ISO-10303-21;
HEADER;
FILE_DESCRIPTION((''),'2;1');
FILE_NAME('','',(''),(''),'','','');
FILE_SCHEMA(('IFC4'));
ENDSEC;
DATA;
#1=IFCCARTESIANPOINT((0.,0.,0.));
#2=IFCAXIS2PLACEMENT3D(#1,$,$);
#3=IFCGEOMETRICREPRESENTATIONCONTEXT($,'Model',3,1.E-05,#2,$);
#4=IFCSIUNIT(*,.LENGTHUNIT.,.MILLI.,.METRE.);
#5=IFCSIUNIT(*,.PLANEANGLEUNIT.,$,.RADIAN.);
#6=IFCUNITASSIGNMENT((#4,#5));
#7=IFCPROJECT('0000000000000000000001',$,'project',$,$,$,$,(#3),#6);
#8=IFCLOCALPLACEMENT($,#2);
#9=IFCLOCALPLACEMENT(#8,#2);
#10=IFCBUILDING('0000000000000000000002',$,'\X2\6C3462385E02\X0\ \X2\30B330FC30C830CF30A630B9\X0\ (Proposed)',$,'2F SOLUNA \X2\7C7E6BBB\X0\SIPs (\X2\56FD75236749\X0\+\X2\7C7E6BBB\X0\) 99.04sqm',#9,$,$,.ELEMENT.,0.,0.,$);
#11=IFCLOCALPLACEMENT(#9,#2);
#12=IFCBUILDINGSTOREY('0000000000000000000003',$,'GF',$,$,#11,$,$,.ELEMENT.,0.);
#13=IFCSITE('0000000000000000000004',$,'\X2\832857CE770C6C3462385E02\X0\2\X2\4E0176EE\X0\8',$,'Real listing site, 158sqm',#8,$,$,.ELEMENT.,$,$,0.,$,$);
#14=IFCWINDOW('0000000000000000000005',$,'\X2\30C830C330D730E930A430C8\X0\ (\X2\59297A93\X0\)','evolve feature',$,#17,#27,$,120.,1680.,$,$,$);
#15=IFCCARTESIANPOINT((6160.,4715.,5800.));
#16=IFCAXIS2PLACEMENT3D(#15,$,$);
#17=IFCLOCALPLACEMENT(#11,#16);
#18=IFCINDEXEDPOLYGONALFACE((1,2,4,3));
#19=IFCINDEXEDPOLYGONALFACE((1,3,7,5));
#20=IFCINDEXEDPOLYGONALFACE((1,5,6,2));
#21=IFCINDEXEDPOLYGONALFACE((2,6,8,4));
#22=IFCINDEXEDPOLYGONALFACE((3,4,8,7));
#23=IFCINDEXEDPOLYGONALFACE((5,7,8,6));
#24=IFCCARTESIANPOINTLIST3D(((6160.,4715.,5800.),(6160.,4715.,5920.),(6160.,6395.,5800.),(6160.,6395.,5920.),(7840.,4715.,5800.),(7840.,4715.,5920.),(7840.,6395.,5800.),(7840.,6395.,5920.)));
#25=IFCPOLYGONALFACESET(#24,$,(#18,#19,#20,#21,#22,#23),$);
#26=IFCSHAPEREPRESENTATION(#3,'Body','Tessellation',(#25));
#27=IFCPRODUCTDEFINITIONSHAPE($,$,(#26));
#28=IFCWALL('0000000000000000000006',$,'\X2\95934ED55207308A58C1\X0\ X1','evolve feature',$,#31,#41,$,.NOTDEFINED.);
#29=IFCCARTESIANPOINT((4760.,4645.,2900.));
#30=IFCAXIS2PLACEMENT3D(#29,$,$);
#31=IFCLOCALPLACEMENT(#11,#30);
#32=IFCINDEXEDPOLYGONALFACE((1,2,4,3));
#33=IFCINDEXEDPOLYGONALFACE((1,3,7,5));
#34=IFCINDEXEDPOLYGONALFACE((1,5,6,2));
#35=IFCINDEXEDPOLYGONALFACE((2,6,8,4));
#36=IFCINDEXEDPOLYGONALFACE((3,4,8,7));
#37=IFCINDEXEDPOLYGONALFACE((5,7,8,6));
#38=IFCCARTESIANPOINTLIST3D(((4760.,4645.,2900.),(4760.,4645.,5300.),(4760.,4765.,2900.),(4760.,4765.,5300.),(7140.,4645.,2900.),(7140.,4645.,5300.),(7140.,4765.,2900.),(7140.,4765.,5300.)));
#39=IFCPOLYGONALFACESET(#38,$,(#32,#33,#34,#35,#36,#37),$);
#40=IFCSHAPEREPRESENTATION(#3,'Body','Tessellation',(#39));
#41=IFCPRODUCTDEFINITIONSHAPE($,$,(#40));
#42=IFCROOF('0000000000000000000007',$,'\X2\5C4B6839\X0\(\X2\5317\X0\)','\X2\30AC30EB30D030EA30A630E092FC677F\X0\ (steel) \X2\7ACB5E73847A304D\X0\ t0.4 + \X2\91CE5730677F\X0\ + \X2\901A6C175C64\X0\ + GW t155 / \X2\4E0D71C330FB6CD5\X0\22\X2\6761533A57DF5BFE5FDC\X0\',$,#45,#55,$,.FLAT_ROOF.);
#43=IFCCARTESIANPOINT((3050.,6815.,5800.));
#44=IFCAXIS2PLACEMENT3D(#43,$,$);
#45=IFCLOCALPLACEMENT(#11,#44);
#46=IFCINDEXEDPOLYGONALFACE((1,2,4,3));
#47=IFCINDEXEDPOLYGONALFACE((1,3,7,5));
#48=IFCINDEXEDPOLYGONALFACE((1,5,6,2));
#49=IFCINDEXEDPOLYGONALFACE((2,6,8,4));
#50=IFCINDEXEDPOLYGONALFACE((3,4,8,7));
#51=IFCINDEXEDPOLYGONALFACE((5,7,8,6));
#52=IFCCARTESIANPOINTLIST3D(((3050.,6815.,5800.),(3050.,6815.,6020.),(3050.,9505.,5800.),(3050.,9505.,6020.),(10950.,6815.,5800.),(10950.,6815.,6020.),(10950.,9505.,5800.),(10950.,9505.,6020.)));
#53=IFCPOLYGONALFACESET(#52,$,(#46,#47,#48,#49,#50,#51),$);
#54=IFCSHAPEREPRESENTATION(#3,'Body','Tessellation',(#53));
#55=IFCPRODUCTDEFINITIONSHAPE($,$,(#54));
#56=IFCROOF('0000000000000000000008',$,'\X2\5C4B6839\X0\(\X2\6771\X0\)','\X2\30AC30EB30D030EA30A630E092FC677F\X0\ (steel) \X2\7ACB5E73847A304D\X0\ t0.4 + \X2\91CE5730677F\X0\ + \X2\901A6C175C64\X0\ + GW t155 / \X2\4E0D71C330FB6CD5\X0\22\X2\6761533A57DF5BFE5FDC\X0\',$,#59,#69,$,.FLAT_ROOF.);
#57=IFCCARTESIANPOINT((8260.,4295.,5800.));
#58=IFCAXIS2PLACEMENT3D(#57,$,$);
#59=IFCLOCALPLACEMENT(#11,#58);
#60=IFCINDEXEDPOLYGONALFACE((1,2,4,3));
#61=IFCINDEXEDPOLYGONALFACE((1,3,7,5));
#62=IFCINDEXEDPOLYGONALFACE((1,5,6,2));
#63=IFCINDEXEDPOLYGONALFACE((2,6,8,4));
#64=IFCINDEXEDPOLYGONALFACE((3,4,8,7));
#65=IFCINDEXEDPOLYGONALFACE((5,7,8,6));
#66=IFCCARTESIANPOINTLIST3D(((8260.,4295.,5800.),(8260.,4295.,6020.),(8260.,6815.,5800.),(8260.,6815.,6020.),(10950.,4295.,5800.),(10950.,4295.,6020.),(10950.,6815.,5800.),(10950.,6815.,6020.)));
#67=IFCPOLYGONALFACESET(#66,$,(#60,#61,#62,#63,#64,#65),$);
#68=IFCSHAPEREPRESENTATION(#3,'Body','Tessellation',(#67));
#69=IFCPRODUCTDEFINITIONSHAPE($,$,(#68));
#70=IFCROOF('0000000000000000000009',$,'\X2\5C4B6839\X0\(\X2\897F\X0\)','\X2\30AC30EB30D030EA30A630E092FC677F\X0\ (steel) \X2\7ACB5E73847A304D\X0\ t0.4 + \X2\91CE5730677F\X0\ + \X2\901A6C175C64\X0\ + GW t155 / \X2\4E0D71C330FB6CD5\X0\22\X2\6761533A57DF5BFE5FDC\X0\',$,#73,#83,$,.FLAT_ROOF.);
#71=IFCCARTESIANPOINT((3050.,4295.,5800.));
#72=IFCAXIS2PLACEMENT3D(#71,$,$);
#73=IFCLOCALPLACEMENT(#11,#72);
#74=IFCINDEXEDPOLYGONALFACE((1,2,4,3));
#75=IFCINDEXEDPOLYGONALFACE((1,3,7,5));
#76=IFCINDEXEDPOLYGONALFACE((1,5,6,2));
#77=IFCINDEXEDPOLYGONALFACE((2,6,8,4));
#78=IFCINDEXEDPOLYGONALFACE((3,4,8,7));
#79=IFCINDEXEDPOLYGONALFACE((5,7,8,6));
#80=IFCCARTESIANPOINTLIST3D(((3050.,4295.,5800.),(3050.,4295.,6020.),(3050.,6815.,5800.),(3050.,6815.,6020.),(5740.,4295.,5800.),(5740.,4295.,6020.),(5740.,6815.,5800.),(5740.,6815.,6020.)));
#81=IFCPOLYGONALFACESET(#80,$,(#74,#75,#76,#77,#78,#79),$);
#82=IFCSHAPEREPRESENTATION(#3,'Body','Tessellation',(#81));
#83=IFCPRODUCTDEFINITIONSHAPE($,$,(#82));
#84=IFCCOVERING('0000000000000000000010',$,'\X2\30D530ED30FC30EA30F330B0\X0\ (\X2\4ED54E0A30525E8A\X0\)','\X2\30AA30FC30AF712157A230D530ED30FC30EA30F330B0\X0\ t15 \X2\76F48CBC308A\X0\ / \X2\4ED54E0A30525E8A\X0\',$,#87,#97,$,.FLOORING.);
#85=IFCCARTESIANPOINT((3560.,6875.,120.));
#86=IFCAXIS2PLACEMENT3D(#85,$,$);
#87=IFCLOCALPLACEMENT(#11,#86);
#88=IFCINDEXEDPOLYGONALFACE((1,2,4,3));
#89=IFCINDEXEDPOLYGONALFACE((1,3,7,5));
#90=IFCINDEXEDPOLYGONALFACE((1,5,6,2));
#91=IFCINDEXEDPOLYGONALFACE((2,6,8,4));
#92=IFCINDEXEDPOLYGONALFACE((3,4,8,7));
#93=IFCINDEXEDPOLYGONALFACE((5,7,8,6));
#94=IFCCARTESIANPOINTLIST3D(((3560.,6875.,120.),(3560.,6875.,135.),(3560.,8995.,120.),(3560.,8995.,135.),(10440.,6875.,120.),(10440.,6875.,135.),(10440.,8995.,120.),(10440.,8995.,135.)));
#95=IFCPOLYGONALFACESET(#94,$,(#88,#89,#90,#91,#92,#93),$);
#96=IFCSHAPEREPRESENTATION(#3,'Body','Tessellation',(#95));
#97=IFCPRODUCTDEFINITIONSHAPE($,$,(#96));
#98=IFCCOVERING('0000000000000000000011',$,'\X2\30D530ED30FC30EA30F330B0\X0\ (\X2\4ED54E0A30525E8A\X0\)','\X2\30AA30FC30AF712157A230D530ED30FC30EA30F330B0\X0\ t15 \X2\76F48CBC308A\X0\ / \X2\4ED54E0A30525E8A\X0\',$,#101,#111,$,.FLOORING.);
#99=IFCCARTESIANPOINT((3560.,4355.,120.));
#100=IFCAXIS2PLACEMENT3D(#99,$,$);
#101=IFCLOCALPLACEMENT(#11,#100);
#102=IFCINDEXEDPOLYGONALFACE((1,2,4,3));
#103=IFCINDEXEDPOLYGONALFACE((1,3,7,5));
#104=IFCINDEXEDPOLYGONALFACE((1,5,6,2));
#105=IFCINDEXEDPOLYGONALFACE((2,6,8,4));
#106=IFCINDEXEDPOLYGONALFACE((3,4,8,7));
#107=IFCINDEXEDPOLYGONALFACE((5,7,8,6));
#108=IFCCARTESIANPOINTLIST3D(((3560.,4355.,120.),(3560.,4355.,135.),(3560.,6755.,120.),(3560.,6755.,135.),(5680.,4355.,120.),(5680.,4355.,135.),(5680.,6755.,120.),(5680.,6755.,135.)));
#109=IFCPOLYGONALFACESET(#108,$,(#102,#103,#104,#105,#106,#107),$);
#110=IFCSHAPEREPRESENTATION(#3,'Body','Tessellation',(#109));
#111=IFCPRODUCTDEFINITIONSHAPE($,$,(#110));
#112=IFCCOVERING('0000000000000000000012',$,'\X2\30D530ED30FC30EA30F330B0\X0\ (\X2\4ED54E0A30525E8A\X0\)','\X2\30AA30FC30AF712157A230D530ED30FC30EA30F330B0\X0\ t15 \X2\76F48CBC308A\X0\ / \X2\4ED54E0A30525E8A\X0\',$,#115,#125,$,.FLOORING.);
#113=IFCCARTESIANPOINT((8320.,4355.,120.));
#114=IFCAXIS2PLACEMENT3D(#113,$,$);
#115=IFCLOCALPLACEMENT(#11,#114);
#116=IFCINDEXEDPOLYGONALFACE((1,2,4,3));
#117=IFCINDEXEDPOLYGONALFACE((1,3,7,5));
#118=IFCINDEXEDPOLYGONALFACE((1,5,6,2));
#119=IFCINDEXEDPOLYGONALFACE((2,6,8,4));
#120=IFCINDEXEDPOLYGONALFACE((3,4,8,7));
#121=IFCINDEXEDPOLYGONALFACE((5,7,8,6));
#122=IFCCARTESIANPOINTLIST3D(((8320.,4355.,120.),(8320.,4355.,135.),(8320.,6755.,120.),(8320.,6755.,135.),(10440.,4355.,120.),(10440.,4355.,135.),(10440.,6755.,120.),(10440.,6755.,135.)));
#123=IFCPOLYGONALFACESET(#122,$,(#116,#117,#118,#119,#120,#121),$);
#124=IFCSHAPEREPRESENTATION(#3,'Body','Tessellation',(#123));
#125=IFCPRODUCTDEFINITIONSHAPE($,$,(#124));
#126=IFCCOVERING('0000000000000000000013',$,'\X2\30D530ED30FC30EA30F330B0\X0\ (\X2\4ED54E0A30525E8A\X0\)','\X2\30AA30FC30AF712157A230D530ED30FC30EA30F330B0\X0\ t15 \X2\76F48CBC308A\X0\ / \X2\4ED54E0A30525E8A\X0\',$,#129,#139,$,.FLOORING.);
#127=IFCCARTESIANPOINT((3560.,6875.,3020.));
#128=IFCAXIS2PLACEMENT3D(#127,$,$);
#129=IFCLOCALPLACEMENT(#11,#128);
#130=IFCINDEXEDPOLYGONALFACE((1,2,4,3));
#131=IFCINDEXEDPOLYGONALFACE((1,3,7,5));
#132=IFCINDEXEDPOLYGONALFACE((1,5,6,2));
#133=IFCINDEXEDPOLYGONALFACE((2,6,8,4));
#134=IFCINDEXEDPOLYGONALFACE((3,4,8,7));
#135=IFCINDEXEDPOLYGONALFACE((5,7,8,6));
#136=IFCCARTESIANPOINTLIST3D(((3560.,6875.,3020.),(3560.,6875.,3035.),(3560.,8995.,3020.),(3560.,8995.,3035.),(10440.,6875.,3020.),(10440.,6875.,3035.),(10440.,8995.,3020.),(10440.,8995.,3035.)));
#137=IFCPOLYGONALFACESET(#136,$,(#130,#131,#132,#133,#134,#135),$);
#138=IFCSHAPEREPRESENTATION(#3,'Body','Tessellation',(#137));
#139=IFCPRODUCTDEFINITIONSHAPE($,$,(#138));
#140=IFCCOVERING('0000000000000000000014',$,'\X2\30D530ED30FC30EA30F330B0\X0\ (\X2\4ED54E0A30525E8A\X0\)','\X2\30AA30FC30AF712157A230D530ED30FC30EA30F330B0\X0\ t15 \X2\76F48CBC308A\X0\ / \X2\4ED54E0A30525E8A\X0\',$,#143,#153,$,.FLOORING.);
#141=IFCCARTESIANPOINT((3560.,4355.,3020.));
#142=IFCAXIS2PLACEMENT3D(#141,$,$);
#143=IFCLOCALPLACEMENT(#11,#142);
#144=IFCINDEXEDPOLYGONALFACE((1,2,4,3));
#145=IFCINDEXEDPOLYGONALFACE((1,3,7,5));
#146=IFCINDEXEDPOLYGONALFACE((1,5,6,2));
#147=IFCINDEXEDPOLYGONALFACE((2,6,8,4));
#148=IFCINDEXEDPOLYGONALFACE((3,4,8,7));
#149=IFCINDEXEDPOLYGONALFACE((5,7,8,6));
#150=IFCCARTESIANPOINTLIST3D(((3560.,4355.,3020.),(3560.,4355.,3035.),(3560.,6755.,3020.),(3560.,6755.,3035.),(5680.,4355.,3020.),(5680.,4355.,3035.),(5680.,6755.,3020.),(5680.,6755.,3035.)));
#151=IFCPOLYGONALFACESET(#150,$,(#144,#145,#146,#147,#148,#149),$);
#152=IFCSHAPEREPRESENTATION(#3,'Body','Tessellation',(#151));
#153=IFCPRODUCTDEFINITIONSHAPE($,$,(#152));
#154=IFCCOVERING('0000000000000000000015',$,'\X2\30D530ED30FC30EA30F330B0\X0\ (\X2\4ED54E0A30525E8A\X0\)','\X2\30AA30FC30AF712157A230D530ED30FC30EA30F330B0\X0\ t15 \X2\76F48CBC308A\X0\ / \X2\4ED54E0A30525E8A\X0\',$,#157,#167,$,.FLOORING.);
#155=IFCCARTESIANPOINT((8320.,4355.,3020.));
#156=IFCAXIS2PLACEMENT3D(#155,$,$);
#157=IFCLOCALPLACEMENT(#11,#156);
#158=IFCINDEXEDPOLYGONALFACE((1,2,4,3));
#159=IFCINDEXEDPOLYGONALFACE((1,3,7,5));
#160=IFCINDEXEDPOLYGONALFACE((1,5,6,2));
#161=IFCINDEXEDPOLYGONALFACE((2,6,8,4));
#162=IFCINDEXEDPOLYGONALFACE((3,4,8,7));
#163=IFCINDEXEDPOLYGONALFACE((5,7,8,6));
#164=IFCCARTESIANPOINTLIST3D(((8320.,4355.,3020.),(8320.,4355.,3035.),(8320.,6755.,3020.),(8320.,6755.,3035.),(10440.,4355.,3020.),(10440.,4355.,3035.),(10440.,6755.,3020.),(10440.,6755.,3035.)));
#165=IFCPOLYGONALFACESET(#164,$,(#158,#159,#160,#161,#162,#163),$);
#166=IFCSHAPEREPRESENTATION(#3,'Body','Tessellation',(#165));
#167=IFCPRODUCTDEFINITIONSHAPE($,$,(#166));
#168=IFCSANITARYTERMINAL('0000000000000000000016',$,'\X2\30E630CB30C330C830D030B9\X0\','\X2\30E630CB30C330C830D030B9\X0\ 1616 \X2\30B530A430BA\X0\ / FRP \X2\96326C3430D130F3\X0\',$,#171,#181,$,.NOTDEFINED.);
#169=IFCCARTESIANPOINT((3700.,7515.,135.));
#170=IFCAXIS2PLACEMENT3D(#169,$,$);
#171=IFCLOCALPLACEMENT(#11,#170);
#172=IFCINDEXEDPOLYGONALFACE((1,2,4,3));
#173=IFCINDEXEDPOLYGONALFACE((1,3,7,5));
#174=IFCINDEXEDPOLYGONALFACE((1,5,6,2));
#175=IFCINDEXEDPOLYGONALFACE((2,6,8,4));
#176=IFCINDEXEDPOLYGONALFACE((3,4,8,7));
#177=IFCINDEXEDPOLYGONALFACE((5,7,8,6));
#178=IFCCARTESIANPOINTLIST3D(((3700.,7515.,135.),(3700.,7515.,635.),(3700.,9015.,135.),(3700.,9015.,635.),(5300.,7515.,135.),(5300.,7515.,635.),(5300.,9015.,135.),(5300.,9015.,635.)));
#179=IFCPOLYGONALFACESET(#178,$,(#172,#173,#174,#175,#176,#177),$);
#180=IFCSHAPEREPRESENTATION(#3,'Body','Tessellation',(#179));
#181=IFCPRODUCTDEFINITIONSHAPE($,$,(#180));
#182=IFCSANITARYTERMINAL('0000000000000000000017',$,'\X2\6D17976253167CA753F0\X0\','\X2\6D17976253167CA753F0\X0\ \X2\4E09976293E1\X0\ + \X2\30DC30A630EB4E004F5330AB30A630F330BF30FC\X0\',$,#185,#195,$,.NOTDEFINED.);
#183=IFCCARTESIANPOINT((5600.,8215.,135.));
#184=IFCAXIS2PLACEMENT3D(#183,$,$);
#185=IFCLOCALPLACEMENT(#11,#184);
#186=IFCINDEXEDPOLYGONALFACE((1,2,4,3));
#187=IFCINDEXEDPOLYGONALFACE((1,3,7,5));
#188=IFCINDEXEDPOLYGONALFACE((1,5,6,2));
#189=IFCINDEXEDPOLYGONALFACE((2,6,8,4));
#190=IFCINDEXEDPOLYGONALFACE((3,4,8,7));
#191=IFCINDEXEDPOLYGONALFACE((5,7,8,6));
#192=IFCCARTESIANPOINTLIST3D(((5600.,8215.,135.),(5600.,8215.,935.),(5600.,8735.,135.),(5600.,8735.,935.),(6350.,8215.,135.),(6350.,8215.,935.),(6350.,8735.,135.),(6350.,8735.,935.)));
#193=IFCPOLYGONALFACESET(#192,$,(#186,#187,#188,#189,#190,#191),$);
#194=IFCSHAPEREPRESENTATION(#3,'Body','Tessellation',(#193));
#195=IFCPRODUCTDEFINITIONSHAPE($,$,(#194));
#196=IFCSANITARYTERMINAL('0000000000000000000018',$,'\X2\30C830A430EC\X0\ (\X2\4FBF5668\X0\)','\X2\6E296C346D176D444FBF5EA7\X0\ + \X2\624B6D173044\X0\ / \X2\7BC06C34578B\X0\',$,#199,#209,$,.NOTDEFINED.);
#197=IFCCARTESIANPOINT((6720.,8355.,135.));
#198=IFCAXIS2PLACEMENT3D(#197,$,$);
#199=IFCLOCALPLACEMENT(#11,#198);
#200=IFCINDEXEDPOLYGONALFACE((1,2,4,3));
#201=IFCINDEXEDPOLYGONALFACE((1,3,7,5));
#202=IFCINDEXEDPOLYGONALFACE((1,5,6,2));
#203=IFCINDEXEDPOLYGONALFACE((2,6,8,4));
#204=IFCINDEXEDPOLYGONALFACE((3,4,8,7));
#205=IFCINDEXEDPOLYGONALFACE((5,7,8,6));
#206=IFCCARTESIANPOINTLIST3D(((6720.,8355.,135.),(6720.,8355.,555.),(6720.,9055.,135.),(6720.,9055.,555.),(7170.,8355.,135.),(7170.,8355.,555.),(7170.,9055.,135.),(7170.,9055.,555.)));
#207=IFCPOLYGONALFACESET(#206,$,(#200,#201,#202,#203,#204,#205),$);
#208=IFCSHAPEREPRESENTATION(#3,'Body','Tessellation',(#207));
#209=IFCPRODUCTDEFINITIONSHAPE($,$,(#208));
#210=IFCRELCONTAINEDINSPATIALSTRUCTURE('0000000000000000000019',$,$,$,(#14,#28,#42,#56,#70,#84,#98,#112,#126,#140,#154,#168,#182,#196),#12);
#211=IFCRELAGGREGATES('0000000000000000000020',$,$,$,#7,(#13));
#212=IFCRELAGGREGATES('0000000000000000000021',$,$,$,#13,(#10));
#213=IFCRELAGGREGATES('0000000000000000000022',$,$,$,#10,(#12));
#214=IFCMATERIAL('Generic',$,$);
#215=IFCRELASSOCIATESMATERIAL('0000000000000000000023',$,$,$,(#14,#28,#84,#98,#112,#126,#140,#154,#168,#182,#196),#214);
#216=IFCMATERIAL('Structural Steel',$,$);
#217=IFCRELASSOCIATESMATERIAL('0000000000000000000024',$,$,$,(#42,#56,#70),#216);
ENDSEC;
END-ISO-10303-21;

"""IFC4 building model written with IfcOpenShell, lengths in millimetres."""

from ifc_helpers import new_model, si_unit, frame, frame_2d, origin, place, context, project, spatial, rectangle, extrude, material, element, save


model = new_model("IFC4")

# Units and contexts
model_context = context("Model", 3, precision=1e-05, world=origin())
ifc_project = project(units=[si_unit("LENGTHUNIT", "METRE", prefix="MILLI"), si_unit("PLANEANGLEUNIT", "RADIAN")], contexts=[model_context])

# Site, building, storey
site_placement = place(None, origin())
site = spatial("IfcSite", under=ifc_project, at=site_placement, Name="茨城県水戸市2丁目8", ObjectType="Real listing site, 158sqm", CompositionType="ELEMENT", RefElevation=0.0)
building_placement = place(site_placement, origin())
building = spatial("IfcBuilding", under=site, at=building_placement, Name="水戸市 コートハウス (Proposed)", ObjectType="2F SOLUNA 籾殻SIPs (国産杉+籾殻) 99.04sqm", CompositionType="ELEMENT", ElevationOfRefHeight=0.0, ElevationOfTerrain=0.0)
storey_placement = place(building_placement, origin())
storey = spatial("IfcBuildingStorey", under=building, at=storey_placement, Name="GF", CompositionType="ELEMENT", Elevation=0.0)

# Window
ifc_material_1 = material(Name="Generic")
window_1_placement = place(storey_placement, frame((6160.0, 4715.0, 5800.0)))
element("IfcWindow", 1, at=window_1_placement, inside=storey, material=ifc_material_1, Name="トップライト (天窓)", Description="evolve feature", OverallHeight=120.0, OverallWidth=1680.0, context=model_context, shape_type="SweptSolid", body=[
    extrude(rectangle(XDim=1680.0, YDim=1680.0, at=frame_2d((840.0, 840.0))), frame((6160.0, 4715.0, 5800.0)), (0.0, 0.0, 1.0), 120.0),
])

# Wall
wall_1_placement = place(storey_placement, frame((4760.0, 4645.0, 2900.0)))
element("IfcWall", 2, at=wall_1_placement, inside=storey, material=ifc_material_1, Name="間仕切り壁 X1", Description="evolve feature", PredefinedType="NOTDEFINED", context=model_context, shape_type="SweptSolid", body=[
    extrude(rectangle(XDim=2380.0, YDim=120.0, at=frame_2d((1190.0, 60.0))), frame((4760.0, 4645.0, 2900.0)), (0.0, 0.0, 1.0), 2400.0),
])

# Roofs
ifc_material_2 = material(Name="Structural Steel")
roof_1_placement = place(storey_placement, frame((3050.0, 6815.0, 5800.0)))
element("IfcRoof", 3, at=roof_1_placement, inside=storey, material=ifc_material_2, Name="屋根(北)", Description="ガルバリウム鋼板 (steel) 立平葺き t0.4 + 野地板 + 通気層 + GW t155 / 不燃・法22条区域対応", PredefinedType="FLAT_ROOF", context=model_context, shape_type="SweptSolid", body=[
    extrude(rectangle(XDim=7900.0, YDim=2690.0, at=frame_2d((3950.0, 1345.0))), frame((3050.0, 6815.0, 5800.0)), (0.0, 0.0, 1.0), 220.0),
])
roof_2_placement = place(storey_placement, frame((8260.0, 4295.0, 5800.0)))
element("IfcRoof", 4, at=roof_2_placement, inside=storey, material=ifc_material_2, Name="屋根(東)", Description="ガルバリウム鋼板 (steel) 立平葺き t0.4 + 野地板 + 通気層 + GW t155 / 不燃・法22条区域対応", PredefinedType="FLAT_ROOF", context=model_context, shape_type="SweptSolid", body=[
    extrude(rectangle(XDim=2690.0, YDim=2520.0, at=frame_2d((1345.0, 1260.0))), frame((8260.0, 4295.0, 5800.0)), (0.0, 0.0, 1.0), 220.0),
])
roof_3_placement = place(storey_placement, frame((3050.0, 4295.0, 5800.0)))
element("IfcRoof", 5, at=roof_3_placement, inside=storey, material=ifc_material_2, Name="屋根(西)", Description="ガルバリウム鋼板 (steel) 立平葺き t0.4 + 野地板 + 通気層 + GW t155 / 不燃・法22条区域対応", PredefinedType="FLAT_ROOF", context=model_context, shape_type="SweptSolid", body=[
    extrude(rectangle(XDim=2690.0, YDim=2520.0, at=frame_2d((1345.0, 1260.0))), frame((3050.0, 4295.0, 5800.0)), (0.0, 0.0, 1.0), 220.0),
])

# Coverings
covering_1_placement = place(storey_placement, frame((3560.0, 6875.0, 120.0)))
element("IfcCovering", 6, at=covering_1_placement, inside=storey, material=ifc_material_1, Name="フローリング (仕上げ床)", Description="オーク無垢フローリング t15 直貼り / 仕上げ床", PredefinedType="FLOORING", context=model_context, shape_type="SweptSolid", body=[
    extrude(rectangle(XDim=6880.0, YDim=2120.0, at=frame_2d((3440.0, 1060.0))), frame((3560.0, 6875.0, 120.0)), (0.0, 0.0, 1.0), 15.0),
])
covering_2_placement = place(storey_placement, frame((3560.0, 4355.0, 120.0)))
element("IfcCovering", 7, at=covering_2_placement, inside=storey, material=ifc_material_1, Name="フローリング (仕上げ床)", Description="オーク無垢フローリング t15 直貼り / 仕上げ床", PredefinedType="FLOORING", context=model_context, shape_type="SweptSolid", body=[
    extrude(rectangle(XDim=2120.0, YDim=2400.0, at=frame_2d((1060.0, 1200.0))), frame((3560.0, 4355.0, 120.0)), (0.0, 0.0, 1.0), 15.0),
])
covering_3_placement = place(storey_placement, frame((8320.0, 4355.0, 120.0)))
element("IfcCovering", 8, at=covering_3_placement, inside=storey, material=ifc_material_1, Name="フローリング (仕上げ床)", Description="オーク無垢フローリング t15 直貼り / 仕上げ床", PredefinedType="FLOORING", context=model_context, shape_type="SweptSolid", body=[
    extrude(rectangle(XDim=2120.0, YDim=2400.0, at=frame_2d((1060.0, 1200.0))), frame((8320.0, 4355.0, 120.0)), (0.0, 0.0, 1.0), 15.0),
])
covering_4_placement = place(storey_placement, frame((3560.0, 6875.0, 3020.0)))
element("IfcCovering", 9, at=covering_4_placement, inside=storey, material=ifc_material_1, Name="フローリング (仕上げ床)", Description="オーク無垢フローリング t15 直貼り / 仕上げ床", PredefinedType="FLOORING", context=model_context, shape_type="SweptSolid", body=[
    extrude(rectangle(XDim=6880.0, YDim=2120.0, at=frame_2d((3440.0, 1060.0))), frame((3560.0, 6875.0, 3020.0)), (0.0, 0.0, 1.0), 15.0),
])
covering_5_placement = place(storey_placement, frame((3560.0, 4355.0, 3020.0)))
element("IfcCovering", 10, at=covering_5_placement, inside=storey, material=ifc_material_1, Name="フローリング (仕上げ床)", Description="オーク無垢フローリング t15 直貼り / 仕上げ床", PredefinedType="FLOORING", context=model_context, shape_type="SweptSolid", body=[
    extrude(rectangle(XDim=2120.0, YDim=2400.0, at=frame_2d((1060.0, 1200.0))), frame((3560.0, 4355.0, 3020.0)), (0.0, 0.0, 1.0), 15.0),
])
covering_6_placement = place(storey_placement, frame((8320.0, 4355.0, 3020.0)))
element("IfcCovering", 11, at=covering_6_placement, inside=storey, material=ifc_material_1, Name="フローリング (仕上げ床)", Description="オーク無垢フローリング t15 直貼り / 仕上げ床", PredefinedType="FLOORING", context=model_context, shape_type="SweptSolid", body=[
    extrude(rectangle(XDim=2120.0, YDim=2400.0, at=frame_2d((1060.0, 1200.0))), frame((8320.0, 4355.0, 3020.0)), (0.0, 0.0, 1.0), 15.0),
])

# Sanitary terminals
sanitary_terminal_1_placement = place(storey_placement, frame((3700.0, 7515.0, 135.0)))
element("IfcSanitaryTerminal", 12, at=sanitary_terminal_1_placement, inside=storey, material=ifc_material_1, Name="ユニットバス", Description="ユニットバス 1616 サイズ / FRP 防水パン", PredefinedType="NOTDEFINED", context=model_context, shape_type="SweptSolid", body=[
    extrude(rectangle(XDim=1600.0, YDim=1500.0, at=frame_2d((800.0, 750.0))), frame((3700.0, 7515.0, 135.0)), (0.0, 0.0, 1.0), 500.0),
])
sanitary_terminal_2_placement = place(storey_placement, frame((5600.0, 8215.0, 135.0)))
element("IfcSanitaryTerminal", 13, at=sanitary_terminal_2_placement, inside=storey, material=ifc_material_1, Name="洗面化粧台", Description="洗面化粧台 三面鏡 + ボウル一体カウンター", PredefinedType="NOTDEFINED", context=model_context, shape_type="SweptSolid", body=[
    extrude(rectangle(XDim=750.0, YDim=520.0, at=frame_2d((375.0, 260.0))), frame((5600.0, 8215.0, 135.0)), (0.0, 0.0, 1.0), 800.0),
])
sanitary_terminal_3_placement = place(storey_placement, frame((6720.0, 8355.0, 135.0)))
element("IfcSanitaryTerminal", 14, at=sanitary_terminal_3_placement, inside=storey, material=ifc_material_1, Name="トイレ (便器)", Description="温水洗浄便座 + 手洗い / 節水型", PredefinedType="NOTDEFINED", context=model_context, shape_type="SweptSolid", body=[
    extrude(rectangle(XDim=450.0, YDim=700.0, at=frame_2d((225.0, 350.0))), frame((6720.0, 8355.0, 135.0)), (0.0, 0.0, 1.0), 420.0),
])

save(model, "model.ifc")
